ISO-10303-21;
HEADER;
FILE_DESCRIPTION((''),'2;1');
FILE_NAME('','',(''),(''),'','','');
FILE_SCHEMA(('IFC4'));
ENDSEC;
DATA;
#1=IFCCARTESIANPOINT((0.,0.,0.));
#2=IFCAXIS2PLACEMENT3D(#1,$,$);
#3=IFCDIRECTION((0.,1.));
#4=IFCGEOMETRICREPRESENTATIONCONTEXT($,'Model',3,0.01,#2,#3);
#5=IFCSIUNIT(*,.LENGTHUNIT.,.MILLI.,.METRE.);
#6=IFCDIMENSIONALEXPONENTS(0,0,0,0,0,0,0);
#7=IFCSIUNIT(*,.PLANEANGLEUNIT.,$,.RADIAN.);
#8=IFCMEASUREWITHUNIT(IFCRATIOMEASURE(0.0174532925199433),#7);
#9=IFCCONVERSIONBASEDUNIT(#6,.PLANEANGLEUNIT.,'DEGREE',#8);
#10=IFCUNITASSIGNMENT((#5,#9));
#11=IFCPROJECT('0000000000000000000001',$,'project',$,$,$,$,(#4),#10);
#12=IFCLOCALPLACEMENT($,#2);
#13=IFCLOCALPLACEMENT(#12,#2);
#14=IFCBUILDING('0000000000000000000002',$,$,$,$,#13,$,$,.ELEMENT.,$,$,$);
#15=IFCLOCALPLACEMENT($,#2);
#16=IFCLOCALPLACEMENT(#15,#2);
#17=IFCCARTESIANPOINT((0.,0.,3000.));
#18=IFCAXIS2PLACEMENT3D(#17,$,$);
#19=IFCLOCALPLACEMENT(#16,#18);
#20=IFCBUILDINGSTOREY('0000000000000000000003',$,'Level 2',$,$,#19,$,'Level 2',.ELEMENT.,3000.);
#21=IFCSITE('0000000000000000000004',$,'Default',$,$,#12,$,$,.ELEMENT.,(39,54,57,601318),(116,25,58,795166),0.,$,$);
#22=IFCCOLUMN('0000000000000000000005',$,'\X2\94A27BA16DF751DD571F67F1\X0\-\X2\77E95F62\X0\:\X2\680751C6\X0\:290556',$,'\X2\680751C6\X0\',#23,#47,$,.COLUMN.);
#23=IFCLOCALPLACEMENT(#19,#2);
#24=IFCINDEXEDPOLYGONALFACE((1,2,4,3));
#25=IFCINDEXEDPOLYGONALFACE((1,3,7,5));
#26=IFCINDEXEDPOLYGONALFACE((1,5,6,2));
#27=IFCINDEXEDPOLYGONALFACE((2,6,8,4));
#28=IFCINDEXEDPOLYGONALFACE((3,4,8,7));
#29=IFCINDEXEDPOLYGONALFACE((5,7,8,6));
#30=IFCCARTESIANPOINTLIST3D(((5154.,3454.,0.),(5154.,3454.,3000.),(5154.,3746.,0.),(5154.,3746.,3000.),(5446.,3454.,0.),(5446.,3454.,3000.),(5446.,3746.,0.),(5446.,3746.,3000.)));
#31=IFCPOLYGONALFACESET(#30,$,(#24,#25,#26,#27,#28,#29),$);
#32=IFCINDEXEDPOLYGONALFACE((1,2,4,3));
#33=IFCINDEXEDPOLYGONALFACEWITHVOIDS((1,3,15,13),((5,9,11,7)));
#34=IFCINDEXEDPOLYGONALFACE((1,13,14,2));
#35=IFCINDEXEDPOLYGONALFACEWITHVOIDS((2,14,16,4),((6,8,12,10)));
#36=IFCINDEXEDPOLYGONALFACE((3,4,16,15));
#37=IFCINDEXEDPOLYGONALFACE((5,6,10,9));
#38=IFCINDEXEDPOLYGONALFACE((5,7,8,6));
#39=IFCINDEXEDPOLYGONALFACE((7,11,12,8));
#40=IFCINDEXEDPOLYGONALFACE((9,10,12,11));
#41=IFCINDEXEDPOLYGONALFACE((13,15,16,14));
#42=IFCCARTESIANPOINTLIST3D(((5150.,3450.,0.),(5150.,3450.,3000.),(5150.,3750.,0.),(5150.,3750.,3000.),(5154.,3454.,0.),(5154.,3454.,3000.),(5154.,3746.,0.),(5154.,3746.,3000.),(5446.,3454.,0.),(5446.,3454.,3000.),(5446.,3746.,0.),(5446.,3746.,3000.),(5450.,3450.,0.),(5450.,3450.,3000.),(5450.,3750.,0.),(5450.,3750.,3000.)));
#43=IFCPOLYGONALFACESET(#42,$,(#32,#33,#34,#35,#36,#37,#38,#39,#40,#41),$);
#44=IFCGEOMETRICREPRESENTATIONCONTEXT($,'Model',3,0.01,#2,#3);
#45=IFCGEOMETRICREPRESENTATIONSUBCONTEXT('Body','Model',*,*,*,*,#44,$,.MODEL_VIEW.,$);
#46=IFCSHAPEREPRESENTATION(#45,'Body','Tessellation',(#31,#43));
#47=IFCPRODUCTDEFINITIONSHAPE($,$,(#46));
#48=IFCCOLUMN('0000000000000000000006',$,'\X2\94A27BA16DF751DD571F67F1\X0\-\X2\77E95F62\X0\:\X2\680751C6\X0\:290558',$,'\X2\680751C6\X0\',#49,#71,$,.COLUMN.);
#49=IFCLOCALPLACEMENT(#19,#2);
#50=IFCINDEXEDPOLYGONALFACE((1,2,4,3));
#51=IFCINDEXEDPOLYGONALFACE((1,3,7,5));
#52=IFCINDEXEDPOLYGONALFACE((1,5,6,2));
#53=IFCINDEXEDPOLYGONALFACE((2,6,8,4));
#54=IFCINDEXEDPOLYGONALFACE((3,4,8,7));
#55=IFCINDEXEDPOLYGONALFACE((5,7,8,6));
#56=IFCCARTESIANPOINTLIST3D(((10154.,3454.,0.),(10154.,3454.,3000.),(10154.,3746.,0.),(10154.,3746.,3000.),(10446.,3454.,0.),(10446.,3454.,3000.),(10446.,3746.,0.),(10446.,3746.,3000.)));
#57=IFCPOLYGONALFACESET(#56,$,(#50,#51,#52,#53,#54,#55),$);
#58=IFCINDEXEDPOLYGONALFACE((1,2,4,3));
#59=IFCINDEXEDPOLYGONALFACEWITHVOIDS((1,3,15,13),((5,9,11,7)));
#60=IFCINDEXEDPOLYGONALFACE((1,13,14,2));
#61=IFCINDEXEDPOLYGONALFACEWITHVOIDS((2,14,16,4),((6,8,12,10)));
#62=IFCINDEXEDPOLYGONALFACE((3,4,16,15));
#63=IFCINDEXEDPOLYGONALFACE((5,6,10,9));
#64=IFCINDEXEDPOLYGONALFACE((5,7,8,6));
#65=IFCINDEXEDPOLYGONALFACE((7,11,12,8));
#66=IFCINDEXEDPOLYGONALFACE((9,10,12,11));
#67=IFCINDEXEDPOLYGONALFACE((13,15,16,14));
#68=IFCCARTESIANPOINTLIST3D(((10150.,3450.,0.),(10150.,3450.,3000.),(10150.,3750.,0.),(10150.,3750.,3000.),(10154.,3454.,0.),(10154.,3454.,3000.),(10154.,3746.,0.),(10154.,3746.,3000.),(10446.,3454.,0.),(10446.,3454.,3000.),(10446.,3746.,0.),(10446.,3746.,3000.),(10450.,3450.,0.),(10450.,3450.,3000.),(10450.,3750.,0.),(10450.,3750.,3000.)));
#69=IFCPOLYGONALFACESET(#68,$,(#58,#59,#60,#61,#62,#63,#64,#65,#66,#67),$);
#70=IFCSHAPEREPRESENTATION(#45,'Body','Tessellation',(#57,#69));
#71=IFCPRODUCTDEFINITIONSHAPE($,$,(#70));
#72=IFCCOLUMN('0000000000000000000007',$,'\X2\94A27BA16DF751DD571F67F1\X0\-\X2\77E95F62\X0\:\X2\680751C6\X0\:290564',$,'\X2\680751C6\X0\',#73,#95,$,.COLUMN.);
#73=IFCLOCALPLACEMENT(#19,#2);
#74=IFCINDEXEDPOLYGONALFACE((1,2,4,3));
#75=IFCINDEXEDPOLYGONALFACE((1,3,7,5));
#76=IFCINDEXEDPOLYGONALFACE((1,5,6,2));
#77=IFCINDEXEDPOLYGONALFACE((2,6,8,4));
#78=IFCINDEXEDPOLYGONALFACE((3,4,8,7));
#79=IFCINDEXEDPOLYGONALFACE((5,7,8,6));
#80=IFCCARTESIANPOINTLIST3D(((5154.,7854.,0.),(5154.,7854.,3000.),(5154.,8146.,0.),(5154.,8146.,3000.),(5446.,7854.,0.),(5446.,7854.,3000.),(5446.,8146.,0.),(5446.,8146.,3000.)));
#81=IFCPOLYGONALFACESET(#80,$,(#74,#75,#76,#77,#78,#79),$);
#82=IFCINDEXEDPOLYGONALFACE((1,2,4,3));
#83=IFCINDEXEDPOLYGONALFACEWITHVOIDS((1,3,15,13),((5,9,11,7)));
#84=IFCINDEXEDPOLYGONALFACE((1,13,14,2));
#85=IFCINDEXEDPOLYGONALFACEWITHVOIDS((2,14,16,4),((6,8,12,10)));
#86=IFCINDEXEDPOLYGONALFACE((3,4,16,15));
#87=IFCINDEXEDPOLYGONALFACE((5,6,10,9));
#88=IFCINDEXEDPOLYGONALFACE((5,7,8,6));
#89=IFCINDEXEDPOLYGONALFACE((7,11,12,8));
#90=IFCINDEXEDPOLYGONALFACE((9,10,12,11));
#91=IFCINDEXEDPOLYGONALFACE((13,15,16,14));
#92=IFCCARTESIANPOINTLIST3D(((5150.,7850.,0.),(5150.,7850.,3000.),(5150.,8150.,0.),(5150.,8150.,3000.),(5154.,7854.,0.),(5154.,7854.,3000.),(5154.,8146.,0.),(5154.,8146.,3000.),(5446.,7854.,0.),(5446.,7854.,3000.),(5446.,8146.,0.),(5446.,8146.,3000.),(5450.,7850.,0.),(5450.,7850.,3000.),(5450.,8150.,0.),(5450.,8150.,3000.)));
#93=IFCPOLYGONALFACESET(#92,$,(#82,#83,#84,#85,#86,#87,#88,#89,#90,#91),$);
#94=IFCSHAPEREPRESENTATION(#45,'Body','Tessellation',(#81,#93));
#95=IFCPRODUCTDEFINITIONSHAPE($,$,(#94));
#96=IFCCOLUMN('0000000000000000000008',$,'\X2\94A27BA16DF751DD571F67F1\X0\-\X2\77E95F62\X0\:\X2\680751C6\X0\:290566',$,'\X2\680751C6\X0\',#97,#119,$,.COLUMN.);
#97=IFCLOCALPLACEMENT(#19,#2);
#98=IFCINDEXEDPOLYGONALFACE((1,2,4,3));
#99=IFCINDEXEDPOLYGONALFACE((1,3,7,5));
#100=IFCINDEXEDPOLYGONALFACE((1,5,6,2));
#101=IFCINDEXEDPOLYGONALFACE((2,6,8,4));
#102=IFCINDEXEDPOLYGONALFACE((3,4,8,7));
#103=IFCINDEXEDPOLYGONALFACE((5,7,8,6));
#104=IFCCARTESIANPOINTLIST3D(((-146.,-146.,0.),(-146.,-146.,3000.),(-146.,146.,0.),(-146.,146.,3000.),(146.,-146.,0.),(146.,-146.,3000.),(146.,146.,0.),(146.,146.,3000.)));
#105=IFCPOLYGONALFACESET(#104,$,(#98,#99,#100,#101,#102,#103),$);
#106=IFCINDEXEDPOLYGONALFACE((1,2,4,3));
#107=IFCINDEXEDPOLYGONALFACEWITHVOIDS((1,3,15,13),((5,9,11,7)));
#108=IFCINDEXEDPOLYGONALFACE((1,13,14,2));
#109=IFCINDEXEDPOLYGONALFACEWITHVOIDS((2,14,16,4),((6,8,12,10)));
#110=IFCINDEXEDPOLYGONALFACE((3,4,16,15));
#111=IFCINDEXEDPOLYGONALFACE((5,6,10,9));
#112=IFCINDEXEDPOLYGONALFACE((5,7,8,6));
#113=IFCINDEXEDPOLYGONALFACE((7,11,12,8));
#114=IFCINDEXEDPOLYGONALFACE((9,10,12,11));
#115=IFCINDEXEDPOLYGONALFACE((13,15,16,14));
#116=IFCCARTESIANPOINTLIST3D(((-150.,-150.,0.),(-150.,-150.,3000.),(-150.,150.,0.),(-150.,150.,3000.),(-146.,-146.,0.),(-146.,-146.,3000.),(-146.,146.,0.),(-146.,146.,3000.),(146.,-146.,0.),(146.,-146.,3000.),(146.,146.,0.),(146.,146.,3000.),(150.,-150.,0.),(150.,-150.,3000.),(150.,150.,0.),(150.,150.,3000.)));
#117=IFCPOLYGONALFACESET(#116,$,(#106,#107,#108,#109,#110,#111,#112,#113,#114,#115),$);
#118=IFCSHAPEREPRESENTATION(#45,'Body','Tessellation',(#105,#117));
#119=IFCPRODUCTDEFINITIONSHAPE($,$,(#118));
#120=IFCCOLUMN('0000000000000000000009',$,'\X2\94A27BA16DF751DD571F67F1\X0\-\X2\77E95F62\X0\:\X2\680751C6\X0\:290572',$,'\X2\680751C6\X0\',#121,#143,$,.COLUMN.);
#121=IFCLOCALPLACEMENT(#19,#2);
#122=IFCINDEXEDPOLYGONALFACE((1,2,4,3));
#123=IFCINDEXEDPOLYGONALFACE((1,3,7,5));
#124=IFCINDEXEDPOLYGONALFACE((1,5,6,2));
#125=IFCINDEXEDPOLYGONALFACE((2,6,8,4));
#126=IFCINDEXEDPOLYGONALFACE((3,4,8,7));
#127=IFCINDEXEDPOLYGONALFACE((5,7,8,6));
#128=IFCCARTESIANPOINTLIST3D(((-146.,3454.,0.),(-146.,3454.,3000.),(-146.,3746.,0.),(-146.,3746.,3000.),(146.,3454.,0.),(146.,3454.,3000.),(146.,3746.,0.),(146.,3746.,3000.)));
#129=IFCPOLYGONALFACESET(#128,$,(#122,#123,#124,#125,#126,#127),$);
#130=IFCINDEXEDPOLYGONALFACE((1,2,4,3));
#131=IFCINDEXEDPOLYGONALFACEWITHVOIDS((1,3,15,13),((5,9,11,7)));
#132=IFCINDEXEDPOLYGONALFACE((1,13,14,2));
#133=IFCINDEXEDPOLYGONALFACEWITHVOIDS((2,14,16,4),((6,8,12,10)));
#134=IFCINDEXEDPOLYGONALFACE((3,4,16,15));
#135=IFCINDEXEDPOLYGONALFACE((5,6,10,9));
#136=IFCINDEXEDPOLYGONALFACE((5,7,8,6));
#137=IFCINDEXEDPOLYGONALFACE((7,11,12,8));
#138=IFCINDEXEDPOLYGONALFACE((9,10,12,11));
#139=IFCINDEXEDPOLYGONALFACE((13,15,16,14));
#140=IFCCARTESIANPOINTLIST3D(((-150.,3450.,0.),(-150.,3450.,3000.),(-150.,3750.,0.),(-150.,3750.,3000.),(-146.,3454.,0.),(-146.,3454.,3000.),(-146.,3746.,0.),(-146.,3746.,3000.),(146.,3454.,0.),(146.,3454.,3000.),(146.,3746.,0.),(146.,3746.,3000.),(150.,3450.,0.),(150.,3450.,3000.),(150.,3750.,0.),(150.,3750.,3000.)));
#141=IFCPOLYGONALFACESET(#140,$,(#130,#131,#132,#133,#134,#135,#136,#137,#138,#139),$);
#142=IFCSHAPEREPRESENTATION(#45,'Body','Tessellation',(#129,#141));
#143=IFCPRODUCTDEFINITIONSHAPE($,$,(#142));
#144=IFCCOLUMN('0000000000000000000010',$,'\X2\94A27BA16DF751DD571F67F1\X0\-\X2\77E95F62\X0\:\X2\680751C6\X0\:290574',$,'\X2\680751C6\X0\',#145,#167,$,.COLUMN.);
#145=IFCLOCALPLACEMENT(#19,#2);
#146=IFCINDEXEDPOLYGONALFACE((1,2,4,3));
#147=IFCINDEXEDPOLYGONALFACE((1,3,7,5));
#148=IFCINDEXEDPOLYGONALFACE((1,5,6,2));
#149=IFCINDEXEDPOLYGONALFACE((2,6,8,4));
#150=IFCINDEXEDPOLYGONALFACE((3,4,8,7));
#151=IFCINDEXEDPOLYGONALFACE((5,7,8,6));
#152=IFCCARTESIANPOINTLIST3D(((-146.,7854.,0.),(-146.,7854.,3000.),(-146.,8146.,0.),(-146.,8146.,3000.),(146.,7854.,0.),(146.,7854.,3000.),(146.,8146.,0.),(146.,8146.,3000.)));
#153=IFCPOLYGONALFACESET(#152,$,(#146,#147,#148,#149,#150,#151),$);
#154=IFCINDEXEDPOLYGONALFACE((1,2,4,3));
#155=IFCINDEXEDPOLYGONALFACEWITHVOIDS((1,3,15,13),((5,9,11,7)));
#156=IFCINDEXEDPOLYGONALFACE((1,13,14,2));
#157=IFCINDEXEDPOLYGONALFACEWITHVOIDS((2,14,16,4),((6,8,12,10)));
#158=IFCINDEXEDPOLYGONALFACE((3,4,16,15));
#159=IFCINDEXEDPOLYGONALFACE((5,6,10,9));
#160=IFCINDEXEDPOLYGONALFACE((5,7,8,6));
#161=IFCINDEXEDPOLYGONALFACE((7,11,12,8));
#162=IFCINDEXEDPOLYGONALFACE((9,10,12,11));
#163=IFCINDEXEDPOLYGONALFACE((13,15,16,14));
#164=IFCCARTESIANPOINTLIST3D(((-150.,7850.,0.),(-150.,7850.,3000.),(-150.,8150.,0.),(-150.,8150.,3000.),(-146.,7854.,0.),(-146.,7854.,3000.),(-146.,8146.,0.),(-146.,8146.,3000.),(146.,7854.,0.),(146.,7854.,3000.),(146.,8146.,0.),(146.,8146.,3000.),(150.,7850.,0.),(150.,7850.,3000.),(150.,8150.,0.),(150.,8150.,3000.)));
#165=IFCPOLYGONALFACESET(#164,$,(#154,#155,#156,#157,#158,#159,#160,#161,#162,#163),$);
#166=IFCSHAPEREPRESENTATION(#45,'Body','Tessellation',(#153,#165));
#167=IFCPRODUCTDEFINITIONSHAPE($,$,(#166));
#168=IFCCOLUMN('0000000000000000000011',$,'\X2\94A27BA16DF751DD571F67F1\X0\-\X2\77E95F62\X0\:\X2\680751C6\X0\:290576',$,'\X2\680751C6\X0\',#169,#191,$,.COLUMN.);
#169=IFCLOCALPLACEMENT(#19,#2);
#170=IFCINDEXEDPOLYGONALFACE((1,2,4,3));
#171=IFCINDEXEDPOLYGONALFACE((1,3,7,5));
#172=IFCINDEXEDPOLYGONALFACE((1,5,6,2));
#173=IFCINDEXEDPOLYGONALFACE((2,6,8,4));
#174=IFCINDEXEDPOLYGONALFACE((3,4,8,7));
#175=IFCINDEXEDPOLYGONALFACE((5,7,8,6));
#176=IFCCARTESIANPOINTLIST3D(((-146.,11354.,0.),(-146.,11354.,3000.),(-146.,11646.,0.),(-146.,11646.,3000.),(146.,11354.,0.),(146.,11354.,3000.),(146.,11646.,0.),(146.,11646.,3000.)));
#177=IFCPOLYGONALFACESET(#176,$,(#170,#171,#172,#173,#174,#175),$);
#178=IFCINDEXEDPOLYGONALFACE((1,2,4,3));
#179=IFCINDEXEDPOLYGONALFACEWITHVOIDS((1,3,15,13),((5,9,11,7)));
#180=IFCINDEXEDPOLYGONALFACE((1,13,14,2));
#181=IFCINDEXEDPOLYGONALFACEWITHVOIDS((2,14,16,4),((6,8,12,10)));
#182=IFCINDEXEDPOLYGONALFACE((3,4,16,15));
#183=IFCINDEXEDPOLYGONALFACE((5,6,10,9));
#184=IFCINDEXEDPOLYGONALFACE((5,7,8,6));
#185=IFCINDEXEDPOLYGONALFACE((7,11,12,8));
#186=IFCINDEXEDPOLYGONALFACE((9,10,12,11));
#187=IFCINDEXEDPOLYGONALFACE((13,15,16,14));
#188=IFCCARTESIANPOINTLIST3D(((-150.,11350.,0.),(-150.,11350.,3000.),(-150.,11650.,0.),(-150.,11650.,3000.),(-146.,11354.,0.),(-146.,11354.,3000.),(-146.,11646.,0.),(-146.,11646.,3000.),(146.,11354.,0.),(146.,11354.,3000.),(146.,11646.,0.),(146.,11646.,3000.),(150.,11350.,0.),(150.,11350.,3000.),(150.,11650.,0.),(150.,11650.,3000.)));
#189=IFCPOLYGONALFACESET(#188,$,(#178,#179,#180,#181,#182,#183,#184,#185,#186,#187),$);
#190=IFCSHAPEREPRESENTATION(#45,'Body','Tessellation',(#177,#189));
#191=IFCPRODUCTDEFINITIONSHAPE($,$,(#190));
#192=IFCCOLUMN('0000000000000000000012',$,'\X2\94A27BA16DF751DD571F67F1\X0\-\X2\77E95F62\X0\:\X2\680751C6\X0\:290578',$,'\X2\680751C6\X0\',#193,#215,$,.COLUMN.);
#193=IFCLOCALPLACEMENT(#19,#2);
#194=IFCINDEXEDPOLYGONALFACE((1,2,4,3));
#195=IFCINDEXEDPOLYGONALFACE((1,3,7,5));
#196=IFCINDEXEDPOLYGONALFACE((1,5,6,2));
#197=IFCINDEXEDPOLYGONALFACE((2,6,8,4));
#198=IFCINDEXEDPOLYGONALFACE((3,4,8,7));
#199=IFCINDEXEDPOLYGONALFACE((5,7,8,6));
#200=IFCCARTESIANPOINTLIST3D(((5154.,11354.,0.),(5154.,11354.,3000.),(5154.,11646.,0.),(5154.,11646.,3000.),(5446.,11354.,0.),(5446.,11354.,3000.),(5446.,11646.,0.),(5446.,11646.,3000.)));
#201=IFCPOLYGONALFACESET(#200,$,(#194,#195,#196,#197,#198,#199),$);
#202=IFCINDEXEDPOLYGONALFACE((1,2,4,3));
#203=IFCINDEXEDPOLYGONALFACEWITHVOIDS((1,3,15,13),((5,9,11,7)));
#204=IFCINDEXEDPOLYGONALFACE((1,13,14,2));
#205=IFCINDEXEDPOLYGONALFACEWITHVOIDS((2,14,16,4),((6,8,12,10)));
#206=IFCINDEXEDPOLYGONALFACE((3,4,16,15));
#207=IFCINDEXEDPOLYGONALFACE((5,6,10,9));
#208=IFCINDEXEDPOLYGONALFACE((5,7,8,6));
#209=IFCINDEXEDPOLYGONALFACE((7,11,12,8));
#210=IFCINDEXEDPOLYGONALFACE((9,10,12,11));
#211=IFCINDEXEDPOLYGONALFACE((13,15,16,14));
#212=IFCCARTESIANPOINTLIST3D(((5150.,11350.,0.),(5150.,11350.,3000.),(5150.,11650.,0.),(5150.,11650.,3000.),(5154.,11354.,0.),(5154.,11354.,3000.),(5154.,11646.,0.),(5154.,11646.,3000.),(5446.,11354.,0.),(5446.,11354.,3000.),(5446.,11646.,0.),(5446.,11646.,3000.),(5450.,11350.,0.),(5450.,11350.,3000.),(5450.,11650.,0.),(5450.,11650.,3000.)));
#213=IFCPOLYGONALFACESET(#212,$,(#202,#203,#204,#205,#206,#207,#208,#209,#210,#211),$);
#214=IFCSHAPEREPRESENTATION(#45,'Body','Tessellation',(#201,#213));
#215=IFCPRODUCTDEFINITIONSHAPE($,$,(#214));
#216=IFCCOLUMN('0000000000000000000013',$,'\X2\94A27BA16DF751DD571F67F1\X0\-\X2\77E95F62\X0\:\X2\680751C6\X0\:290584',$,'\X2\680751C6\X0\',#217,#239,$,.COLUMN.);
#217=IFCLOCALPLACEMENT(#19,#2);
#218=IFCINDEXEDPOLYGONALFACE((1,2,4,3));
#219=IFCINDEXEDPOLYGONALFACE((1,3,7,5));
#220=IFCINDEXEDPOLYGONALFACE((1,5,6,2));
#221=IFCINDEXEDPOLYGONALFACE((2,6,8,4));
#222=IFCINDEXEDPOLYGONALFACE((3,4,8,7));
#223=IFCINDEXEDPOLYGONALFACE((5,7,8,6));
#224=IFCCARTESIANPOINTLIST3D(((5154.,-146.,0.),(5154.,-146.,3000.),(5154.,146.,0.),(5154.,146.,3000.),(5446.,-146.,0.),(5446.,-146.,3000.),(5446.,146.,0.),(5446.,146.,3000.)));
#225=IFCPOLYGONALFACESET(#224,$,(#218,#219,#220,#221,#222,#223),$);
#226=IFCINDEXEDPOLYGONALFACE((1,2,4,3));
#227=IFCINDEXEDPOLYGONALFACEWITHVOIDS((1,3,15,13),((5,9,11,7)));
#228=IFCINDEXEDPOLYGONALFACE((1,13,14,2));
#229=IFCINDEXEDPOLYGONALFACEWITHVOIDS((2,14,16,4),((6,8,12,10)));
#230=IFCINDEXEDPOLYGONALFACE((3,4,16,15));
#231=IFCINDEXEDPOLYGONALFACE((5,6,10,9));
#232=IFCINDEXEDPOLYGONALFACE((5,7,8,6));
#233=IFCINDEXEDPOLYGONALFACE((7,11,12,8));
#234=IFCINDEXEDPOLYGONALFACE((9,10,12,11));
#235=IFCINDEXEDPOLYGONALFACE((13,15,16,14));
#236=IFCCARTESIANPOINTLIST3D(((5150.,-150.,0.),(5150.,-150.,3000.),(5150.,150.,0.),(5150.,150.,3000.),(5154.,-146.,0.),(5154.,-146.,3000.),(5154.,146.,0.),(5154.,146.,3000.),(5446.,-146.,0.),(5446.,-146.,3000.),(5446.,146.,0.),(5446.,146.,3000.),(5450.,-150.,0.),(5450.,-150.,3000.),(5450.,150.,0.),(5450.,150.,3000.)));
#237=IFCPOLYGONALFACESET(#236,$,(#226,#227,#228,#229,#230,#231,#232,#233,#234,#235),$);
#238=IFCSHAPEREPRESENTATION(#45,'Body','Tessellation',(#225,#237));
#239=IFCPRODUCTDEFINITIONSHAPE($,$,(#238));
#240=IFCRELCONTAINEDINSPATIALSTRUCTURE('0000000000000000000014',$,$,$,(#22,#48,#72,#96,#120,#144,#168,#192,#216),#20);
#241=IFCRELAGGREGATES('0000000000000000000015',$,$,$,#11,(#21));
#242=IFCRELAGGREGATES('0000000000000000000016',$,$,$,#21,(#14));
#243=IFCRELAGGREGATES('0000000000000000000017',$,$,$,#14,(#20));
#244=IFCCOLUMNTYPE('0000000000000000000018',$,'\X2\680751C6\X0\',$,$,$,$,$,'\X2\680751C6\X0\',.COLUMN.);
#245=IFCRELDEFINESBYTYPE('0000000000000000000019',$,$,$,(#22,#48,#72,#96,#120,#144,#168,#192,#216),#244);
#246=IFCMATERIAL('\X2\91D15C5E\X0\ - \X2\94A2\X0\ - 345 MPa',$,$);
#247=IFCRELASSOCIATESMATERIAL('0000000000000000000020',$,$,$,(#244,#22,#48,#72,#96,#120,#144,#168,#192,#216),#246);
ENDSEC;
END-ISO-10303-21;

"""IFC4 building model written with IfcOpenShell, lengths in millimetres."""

from ifc_helpers import new_model, entity, si_unit, converted_unit, direction, frame, origin, origin_2d_with_axis, place, context, subcontext, project, spatial, polyline, rectangle, outline, extrude, source, transform, mapped, material, type_object, type_shapes, element, save


model = new_model("IFC4")

# Units and contexts
model_context_1 = context("Model", 3, precision=0.01, world=origin(), true_north=direction((0.0, 1.0)))
model_context_2 = context("Model", 3, precision=0.01, world=origin(), true_north=direction((0.0, 1.0)))
body_context = subcontext(model_context_2, "Body", "Model", "MODEL_VIEW")
ifc_project = project(units=[si_unit("LENGTHUNIT", "METRE", prefix="MILLI"), converted_unit("PLANEANGLEUNIT", "DEGREE", entity("IfcRatioMeasure", 0.0174532925199433), si_unit("PLANEANGLEUNIT", "RADIAN"), dimensions=[0, 0, 0, 0, 0, 0, 0])], contexts=[model_context_1])

# Site, building, storey
site_placement = place(None, origin())
site = spatial("IfcSite", under=ifc_project, at=site_placement, Name="Default", CompositionType="ELEMENT", RefLatitude=(39, 54, 57, 601318), RefLongitude=(116, 25, 58, 795166), RefElevation=0.0)
building_placement = place(site_placement, origin())
building = spatial("IfcBuilding", under=site, at=building_placement, CompositionType="ELEMENT")
placement_1 = place(None, origin())
placement_2 = place(placement_1, origin())
storey_placement = place(placement_2, frame((0.0, 0.0, 3000.0)))
storey = spatial("IfcBuildingStorey", under=building, at=storey_placement, Name="Level 2", LongName="Level 2", CompositionType="ELEMENT", Elevation=3000.0)

# Columns
ifc_material_1 = material(Name="金属 - 钢 - 345 MPa")
column_type = type_object("IfcColumnType", Name="标准", ElementType="标准", PredefinedType="COLUMN", material=ifc_material_1)
shared_shape_1 = source(origin(), body_context, "Body", "SweptSolid", [
    extrude(rectangle(XDim=292.0, YDim=292.0, at=origin_2d_with_axis()), frame((150.0, 150.0, 0.0), z_axis=(0.0, 0.0, 1.0), x_axis=(-1.0, 0.0, 0.0)), (0.0, 0.0, 1.0), 3000.0),
    extrude(outline(polyline([(-150.0, -150.0), (150.0, -150.0), (150.0, 150.0), (-150.0, 150.0), (-150.0, -150.0)]), holes=[polyline([(-146.0, -146.0), (-146.0, 146.0), (146.0, 146.0), (146.0, -146.0), (-146.0, -146.0)])]), frame((150.0, 150.0, 0.0), z_axis=(0.0, 0.0, 1.0), x_axis=(-1.0, 0.0, 0.0)), (0.0, 0.0, 1.0), 3000.0),
])
type_shapes(column_type, [shared_shape_1])
for number, where, name in (
    (1, (5150.0, 3450.0, 0.0), "钢管混凝土柱-矩形:标准:290556"),
    (2, (10150.0, 3450.0, 0.0), "钢管混凝土柱-矩形:标准:290558"),
    (3, (5150.0, 7850.0, 0.0), "钢管混凝土柱-矩形:标准:290564"),
    (4, (-150.0, -150.0, 0.0), "钢管混凝土柱-矩形:标准:290566"),
    (5, (-150.0, 3450.0, 0.0), "钢管混凝土柱-矩形:标准:290572"),
    (6, (-150.0, 7850.0, 0.0), "钢管混凝土柱-矩形:标准:290574"),
    (7, (-150.0, 11350.0, 0.0), "钢管混凝土柱-矩形:标准:290576"),
    (8, (5150.0, 11350.0, 0.0), "钢管混凝土柱-矩形:标准:290578"),
    (9, (5150.0, -150.0, 0.0), "钢管混凝土柱-矩形:标准:290584"),
):
    element("IfcColumn", number, at=place(storey_placement, frame(where)), inside=storey, type_object=column_type, material=ifc_material_1, Name=name, ObjectType="标准", PredefinedType="COLUMN", context=body_context, shape_type="MappedRepresentation", body=[
        mapped(shared_shape_1, transform((0.0, 0.0, 0.0), scale=1.0)),
    ])

save(model, "model.ifc")
